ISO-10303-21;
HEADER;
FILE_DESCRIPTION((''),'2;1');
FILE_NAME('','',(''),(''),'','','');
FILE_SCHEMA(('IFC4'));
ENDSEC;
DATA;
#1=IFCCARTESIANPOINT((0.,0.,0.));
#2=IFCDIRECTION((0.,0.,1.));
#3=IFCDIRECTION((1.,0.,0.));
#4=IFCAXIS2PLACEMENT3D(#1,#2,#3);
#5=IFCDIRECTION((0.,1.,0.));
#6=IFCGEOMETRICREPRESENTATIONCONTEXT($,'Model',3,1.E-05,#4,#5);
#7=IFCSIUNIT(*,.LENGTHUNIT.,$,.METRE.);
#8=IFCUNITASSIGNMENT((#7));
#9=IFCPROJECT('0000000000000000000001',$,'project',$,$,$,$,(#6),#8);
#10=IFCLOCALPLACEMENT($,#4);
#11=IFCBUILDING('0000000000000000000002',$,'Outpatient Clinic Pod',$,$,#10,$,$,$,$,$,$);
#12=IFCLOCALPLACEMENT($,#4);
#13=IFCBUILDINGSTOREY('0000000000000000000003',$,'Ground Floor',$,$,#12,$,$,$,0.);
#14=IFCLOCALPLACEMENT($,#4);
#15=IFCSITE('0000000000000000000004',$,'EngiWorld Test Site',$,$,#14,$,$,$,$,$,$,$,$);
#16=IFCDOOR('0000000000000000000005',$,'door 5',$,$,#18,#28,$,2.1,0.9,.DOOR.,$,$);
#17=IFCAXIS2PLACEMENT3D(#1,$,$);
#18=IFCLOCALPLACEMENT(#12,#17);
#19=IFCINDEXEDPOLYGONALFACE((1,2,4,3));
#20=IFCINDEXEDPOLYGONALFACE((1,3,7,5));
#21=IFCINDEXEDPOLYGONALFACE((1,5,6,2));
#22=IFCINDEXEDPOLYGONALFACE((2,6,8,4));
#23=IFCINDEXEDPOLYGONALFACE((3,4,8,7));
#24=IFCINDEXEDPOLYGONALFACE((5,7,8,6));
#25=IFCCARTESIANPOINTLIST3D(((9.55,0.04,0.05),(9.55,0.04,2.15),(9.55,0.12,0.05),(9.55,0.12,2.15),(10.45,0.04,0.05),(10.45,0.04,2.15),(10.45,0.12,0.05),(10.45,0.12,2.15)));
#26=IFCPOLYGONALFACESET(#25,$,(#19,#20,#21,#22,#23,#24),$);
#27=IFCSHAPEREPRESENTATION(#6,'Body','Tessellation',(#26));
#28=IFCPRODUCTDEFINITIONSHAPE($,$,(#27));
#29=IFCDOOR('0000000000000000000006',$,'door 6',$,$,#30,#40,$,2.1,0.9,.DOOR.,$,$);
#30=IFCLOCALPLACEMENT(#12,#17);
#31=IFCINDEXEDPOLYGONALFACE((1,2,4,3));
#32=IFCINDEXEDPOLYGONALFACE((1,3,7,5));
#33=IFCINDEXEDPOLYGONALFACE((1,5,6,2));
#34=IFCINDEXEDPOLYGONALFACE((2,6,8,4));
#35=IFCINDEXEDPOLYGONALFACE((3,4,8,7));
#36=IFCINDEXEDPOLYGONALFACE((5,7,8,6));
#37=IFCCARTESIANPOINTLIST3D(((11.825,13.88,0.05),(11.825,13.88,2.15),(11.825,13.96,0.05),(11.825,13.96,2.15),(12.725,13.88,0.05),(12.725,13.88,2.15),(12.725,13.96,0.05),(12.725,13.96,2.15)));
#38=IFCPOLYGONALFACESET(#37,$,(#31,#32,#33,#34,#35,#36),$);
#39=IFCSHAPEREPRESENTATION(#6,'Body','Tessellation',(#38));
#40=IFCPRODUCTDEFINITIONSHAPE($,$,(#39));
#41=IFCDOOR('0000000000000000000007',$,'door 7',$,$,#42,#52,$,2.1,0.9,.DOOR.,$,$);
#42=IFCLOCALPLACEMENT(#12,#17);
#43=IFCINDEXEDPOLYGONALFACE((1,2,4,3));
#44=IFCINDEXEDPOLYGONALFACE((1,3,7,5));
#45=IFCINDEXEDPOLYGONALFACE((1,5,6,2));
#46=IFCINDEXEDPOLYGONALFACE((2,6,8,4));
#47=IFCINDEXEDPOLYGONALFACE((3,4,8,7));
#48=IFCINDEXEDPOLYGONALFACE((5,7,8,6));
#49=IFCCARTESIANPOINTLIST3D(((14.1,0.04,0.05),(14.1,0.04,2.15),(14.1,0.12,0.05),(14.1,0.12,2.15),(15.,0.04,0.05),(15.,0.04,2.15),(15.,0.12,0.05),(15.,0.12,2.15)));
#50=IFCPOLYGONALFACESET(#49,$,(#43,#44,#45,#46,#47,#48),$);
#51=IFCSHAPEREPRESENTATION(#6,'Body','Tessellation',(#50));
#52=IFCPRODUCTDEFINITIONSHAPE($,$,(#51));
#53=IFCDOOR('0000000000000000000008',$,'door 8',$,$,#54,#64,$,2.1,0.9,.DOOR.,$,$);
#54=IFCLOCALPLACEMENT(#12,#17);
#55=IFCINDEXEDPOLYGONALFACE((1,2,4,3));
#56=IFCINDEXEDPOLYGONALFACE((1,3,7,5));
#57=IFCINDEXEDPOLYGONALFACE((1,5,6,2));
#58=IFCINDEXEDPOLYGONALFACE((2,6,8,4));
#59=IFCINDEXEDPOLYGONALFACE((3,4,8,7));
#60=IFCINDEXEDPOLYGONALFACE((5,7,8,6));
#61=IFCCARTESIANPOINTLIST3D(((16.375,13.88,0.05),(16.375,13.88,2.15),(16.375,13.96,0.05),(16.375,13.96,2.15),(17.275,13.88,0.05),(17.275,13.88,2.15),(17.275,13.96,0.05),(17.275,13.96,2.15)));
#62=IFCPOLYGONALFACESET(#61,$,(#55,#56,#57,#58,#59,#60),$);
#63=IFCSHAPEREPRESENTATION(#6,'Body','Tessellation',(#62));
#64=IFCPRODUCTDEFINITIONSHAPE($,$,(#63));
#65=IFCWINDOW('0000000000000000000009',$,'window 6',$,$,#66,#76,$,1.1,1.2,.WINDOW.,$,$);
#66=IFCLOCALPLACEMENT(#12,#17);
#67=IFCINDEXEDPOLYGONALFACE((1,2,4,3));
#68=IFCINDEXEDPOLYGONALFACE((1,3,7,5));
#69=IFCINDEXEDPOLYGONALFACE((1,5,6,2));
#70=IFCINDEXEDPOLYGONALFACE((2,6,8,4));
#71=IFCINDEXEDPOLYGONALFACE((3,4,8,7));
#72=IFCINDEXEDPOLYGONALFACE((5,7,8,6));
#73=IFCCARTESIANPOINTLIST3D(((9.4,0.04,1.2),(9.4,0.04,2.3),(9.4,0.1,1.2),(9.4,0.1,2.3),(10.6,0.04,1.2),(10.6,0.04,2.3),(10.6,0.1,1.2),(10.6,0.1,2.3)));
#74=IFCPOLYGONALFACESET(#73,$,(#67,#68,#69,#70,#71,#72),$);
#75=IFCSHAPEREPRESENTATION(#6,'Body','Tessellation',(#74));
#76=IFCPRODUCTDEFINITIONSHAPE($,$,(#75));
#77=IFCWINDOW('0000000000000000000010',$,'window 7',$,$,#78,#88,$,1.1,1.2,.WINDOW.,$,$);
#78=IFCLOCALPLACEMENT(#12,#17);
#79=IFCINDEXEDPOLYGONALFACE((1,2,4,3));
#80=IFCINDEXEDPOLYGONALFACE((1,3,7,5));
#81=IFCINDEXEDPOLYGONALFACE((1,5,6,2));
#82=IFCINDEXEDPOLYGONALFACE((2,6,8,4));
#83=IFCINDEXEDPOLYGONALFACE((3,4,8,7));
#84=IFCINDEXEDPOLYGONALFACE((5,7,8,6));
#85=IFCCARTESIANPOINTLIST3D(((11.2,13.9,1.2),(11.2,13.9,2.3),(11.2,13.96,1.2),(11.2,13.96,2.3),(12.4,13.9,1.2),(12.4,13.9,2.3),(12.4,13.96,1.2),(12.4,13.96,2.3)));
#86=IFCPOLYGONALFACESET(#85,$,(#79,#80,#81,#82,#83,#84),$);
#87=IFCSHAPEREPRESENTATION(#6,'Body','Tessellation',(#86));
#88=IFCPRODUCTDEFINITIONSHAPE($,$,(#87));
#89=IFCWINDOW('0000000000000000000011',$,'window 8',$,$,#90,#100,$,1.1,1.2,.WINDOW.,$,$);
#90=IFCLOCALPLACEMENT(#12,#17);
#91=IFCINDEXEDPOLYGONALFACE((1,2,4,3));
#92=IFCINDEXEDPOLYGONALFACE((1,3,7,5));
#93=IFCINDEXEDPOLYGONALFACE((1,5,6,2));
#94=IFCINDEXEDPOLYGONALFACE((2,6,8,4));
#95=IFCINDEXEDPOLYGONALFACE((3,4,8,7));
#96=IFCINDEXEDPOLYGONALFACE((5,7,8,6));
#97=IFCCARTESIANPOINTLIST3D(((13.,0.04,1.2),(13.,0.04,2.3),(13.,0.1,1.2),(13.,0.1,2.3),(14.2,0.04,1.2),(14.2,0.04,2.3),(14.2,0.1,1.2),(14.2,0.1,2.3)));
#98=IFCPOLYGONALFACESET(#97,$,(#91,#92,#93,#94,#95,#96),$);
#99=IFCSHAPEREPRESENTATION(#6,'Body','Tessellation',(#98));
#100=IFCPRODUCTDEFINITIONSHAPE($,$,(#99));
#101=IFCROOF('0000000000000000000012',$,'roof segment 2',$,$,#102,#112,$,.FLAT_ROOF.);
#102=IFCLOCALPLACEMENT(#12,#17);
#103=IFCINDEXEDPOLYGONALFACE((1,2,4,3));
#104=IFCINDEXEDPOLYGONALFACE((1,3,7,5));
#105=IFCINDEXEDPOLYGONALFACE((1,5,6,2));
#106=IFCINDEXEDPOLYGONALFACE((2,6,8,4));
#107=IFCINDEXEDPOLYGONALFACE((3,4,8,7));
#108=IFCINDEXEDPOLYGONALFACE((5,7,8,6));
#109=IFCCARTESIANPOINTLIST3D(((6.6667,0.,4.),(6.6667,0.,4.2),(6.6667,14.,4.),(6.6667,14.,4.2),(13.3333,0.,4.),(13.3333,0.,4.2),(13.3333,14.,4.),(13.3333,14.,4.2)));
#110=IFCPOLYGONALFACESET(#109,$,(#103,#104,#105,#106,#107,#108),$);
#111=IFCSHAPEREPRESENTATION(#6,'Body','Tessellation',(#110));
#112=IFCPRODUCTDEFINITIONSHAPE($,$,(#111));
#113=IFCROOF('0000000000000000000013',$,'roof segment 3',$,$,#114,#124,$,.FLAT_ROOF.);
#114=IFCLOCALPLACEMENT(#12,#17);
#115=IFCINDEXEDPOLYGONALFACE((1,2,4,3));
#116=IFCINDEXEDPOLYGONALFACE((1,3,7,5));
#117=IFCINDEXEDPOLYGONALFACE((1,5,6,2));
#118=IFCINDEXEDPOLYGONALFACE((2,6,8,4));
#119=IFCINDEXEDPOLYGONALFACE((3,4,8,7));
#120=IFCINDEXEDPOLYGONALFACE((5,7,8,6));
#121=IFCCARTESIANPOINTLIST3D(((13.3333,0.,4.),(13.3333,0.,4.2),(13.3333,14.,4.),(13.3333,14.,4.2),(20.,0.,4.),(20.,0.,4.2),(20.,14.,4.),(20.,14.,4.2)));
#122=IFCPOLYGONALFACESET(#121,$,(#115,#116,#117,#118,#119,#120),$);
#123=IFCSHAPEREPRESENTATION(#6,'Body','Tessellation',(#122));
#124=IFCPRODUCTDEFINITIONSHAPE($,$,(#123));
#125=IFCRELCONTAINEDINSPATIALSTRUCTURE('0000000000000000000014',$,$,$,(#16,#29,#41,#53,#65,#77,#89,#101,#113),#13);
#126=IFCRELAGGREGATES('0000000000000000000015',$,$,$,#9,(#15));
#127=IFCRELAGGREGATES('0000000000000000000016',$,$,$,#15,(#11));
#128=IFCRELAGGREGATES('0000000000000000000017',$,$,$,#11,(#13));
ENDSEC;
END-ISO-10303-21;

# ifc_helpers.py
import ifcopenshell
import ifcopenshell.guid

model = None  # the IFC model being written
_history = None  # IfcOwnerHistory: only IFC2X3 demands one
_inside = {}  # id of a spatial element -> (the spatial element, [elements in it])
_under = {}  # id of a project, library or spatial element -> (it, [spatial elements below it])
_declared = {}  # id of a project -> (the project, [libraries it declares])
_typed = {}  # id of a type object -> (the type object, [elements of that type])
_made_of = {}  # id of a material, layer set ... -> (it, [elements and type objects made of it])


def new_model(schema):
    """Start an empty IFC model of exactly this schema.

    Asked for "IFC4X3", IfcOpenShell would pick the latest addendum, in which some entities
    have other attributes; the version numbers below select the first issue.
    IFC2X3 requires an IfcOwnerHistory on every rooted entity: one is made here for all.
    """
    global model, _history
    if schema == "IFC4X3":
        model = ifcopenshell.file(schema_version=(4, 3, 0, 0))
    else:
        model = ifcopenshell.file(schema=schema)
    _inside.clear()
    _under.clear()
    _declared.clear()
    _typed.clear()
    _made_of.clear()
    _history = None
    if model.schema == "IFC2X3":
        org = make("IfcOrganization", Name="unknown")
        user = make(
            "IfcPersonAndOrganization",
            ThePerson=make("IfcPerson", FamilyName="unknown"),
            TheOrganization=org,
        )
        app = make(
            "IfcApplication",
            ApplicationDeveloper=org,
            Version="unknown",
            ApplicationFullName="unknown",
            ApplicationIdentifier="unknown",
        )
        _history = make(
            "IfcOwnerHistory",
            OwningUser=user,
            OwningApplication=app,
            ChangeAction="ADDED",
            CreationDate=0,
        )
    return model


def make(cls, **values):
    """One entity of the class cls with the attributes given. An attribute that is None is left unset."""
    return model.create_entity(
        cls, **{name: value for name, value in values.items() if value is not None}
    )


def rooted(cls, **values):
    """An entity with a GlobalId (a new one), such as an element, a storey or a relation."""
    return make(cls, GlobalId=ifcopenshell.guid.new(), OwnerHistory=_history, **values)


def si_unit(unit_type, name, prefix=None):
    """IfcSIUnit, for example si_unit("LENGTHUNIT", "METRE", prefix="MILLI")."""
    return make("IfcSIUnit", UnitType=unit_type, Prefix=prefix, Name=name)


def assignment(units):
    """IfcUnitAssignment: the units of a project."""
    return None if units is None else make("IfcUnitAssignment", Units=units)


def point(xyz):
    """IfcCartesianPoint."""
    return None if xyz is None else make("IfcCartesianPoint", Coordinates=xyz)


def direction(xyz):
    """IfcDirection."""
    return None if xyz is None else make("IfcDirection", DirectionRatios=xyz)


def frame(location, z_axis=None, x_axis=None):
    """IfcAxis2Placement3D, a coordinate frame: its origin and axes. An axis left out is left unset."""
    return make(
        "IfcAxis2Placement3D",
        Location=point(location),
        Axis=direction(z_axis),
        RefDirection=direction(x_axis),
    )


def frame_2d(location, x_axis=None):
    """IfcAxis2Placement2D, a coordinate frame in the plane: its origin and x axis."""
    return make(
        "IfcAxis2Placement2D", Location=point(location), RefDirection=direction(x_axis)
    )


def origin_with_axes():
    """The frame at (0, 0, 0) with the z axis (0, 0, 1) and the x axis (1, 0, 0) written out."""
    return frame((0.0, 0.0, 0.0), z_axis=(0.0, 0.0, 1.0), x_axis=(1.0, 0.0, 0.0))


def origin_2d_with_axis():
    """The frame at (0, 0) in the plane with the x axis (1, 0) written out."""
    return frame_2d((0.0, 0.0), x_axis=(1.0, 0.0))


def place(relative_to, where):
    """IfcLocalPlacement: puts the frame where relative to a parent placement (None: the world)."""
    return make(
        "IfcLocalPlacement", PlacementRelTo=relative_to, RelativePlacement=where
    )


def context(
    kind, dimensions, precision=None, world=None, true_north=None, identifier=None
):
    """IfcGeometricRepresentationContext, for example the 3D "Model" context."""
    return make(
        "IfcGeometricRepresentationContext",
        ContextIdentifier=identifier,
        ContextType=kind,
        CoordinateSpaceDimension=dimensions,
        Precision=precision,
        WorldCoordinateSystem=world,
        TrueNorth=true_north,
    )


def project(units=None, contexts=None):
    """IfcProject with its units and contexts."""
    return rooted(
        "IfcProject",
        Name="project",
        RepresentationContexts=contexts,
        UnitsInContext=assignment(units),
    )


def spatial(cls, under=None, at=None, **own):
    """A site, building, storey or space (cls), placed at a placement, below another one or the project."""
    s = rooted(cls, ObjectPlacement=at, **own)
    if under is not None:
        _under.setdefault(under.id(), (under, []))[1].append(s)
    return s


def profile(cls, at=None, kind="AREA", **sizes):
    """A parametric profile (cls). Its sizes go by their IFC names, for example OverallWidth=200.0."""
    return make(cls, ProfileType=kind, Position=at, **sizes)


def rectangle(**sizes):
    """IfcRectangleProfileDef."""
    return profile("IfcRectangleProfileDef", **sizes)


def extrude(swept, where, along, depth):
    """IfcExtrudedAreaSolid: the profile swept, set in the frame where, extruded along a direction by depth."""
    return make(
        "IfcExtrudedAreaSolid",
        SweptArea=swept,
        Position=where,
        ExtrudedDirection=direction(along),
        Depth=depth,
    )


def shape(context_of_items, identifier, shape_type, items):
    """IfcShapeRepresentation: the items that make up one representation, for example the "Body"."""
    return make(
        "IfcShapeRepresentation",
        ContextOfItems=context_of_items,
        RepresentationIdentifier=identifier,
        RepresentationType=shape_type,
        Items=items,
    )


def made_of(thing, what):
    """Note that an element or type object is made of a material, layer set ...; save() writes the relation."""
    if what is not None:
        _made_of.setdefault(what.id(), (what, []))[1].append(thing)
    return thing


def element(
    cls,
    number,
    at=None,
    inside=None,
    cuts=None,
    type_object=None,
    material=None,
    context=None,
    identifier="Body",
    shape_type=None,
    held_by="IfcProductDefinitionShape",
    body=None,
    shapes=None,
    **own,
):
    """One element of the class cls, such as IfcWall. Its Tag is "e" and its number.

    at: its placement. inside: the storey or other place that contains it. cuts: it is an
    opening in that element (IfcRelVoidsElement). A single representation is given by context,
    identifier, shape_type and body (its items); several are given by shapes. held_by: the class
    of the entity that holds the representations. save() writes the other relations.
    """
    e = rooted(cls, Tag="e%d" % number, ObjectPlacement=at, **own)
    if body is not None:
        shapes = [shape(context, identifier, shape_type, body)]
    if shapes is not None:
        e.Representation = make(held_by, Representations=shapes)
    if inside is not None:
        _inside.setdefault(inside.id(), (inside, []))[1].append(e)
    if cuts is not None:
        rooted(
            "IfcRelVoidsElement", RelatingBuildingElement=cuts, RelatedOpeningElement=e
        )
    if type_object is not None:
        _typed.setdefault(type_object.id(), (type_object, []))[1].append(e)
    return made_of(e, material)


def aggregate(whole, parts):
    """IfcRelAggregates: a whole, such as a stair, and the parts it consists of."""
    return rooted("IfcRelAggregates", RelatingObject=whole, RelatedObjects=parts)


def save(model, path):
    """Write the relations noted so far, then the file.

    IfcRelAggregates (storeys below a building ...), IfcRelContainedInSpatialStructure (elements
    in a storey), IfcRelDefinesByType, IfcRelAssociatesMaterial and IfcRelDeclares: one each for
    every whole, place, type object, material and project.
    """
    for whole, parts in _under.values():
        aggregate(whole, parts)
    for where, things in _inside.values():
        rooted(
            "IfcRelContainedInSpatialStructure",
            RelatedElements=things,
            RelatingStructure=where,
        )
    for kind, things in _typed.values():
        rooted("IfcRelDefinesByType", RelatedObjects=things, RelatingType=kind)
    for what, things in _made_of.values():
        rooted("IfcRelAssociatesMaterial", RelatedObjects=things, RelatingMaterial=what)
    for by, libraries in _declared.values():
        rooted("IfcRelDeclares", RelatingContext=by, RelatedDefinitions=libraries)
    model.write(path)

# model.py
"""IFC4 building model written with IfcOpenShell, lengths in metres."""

from ifc_helpers import new_model, si_unit, direction, frame, origin_with_axes, origin_2d_with_axis, place, context, project, spatial, rectangle, extrude, element, save


model = new_model("IFC4")

# Units and contexts
model_context = context("Model", 3, precision=1e-05, world=origin_with_axes(), true_north=direction((0.0, 1.0, 0.0)))
ifc_project = project(units=[si_unit("LENGTHUNIT", "METRE")], contexts=[model_context])

# Site, building, storey
site_placement = place(None, origin_with_axes())
site = spatial("IfcSite", under=ifc_project, at=site_placement, Name="EngiWorld Test Site")
building_placement = place(None, origin_with_axes())
building = spatial("IfcBuilding", under=site, at=building_placement, Name="Outpatient Clinic Pod")
storey_placement = place(None, origin_with_axes())
storey = spatial("IfcBuildingStorey", under=building, at=storey_placement, Name="Ground Floor", Elevation=0.0)

# Doors
for number, where, z_axis, x_axis, name in (
    (1, (10.0, 0.08, 0.05), (0.0, 0.0, 1.0), (1.0, 0.0, 0.0), "door 5"),
    (2, (12.275, 13.92, 0.05), (0.0, 0.0, 1.0), (1.0, 0.0, 0.0), "door 6"),
    (3, (14.55, 0.08, 0.05), (0.0, 0.0, 1.0), (1.0, 0.0, 0.0), "door 7"),
    (4, (16.825, 13.92, 0.05), (0.0, 0.0, 1.0), (1.0, 0.0, 0.0), "door 8"),
):
    element("IfcDoor", number, at=place(None, frame(where, z_axis=z_axis, x_axis=x_axis)), inside=storey, Name=name, OverallHeight=2.1, OverallWidth=0.9, PredefinedType="DOOR", context=model_context, shape_type="SweptSolid", body=[
        extrude(rectangle(XDim=0.9, YDim=0.08, at=origin_2d_with_axis()), origin_with_axes(), (0.0, 0.0, 1.0), 2.1),
    ])

# Windows
for number, where, z_axis, x_axis, name in (
    (5, (10.0, 0.07, 1.2), (0.0, 0.0, 1.0), (1.0, 0.0, 0.0), "window 6"),
    (6, (11.8, 13.93, 1.2), (0.0, 0.0, 1.0), (1.0, 0.0, 0.0), "window 7"),
    (7, (13.6, 0.07, 1.2), (0.0, 0.0, 1.0), (1.0, 0.0, 0.0), "window 8"),
):
    element("IfcWindow", number, at=place(None, frame(where, z_axis=z_axis, x_axis=x_axis)), inside=storey, Name=name, OverallHeight=1.1, OverallWidth=1.2, PredefinedType="WINDOW", context=model_context, shape_type="SweptSolid", body=[
        extrude(rectangle(XDim=1.2, YDim=0.06, at=origin_2d_with_axis()), origin_with_axes(), (0.0, 0.0, 1.0), 1.1),
    ])

# Roofs
for number, where, z_axis, x_axis, name in (
    (8, (10.0, 7.0, 4.0), (0.0, 0.0, 1.0), (1.0, 0.0, 0.0), "roof segment 2"),
    (9, (16.6667, 7.0, 4.0), (0.0, 0.0, 1.0), (1.0, 0.0, 0.0), "roof segment 3"),
):
    element("IfcRoof", number, at=place(None, frame(where, z_axis=z_axis, x_axis=x_axis)), inside=storey, Name=name, PredefinedType="FLAT_ROOF", context=model_context, shape_type="SweptSolid", body=[
        extrude(rectangle(XDim=6.6667, YDim=14.0, at=origin_2d_with_axis()), origin_with_axes(), (0.0, 0.0, 1.0), 0.2),
    ])

save(model, "model.ifc")
